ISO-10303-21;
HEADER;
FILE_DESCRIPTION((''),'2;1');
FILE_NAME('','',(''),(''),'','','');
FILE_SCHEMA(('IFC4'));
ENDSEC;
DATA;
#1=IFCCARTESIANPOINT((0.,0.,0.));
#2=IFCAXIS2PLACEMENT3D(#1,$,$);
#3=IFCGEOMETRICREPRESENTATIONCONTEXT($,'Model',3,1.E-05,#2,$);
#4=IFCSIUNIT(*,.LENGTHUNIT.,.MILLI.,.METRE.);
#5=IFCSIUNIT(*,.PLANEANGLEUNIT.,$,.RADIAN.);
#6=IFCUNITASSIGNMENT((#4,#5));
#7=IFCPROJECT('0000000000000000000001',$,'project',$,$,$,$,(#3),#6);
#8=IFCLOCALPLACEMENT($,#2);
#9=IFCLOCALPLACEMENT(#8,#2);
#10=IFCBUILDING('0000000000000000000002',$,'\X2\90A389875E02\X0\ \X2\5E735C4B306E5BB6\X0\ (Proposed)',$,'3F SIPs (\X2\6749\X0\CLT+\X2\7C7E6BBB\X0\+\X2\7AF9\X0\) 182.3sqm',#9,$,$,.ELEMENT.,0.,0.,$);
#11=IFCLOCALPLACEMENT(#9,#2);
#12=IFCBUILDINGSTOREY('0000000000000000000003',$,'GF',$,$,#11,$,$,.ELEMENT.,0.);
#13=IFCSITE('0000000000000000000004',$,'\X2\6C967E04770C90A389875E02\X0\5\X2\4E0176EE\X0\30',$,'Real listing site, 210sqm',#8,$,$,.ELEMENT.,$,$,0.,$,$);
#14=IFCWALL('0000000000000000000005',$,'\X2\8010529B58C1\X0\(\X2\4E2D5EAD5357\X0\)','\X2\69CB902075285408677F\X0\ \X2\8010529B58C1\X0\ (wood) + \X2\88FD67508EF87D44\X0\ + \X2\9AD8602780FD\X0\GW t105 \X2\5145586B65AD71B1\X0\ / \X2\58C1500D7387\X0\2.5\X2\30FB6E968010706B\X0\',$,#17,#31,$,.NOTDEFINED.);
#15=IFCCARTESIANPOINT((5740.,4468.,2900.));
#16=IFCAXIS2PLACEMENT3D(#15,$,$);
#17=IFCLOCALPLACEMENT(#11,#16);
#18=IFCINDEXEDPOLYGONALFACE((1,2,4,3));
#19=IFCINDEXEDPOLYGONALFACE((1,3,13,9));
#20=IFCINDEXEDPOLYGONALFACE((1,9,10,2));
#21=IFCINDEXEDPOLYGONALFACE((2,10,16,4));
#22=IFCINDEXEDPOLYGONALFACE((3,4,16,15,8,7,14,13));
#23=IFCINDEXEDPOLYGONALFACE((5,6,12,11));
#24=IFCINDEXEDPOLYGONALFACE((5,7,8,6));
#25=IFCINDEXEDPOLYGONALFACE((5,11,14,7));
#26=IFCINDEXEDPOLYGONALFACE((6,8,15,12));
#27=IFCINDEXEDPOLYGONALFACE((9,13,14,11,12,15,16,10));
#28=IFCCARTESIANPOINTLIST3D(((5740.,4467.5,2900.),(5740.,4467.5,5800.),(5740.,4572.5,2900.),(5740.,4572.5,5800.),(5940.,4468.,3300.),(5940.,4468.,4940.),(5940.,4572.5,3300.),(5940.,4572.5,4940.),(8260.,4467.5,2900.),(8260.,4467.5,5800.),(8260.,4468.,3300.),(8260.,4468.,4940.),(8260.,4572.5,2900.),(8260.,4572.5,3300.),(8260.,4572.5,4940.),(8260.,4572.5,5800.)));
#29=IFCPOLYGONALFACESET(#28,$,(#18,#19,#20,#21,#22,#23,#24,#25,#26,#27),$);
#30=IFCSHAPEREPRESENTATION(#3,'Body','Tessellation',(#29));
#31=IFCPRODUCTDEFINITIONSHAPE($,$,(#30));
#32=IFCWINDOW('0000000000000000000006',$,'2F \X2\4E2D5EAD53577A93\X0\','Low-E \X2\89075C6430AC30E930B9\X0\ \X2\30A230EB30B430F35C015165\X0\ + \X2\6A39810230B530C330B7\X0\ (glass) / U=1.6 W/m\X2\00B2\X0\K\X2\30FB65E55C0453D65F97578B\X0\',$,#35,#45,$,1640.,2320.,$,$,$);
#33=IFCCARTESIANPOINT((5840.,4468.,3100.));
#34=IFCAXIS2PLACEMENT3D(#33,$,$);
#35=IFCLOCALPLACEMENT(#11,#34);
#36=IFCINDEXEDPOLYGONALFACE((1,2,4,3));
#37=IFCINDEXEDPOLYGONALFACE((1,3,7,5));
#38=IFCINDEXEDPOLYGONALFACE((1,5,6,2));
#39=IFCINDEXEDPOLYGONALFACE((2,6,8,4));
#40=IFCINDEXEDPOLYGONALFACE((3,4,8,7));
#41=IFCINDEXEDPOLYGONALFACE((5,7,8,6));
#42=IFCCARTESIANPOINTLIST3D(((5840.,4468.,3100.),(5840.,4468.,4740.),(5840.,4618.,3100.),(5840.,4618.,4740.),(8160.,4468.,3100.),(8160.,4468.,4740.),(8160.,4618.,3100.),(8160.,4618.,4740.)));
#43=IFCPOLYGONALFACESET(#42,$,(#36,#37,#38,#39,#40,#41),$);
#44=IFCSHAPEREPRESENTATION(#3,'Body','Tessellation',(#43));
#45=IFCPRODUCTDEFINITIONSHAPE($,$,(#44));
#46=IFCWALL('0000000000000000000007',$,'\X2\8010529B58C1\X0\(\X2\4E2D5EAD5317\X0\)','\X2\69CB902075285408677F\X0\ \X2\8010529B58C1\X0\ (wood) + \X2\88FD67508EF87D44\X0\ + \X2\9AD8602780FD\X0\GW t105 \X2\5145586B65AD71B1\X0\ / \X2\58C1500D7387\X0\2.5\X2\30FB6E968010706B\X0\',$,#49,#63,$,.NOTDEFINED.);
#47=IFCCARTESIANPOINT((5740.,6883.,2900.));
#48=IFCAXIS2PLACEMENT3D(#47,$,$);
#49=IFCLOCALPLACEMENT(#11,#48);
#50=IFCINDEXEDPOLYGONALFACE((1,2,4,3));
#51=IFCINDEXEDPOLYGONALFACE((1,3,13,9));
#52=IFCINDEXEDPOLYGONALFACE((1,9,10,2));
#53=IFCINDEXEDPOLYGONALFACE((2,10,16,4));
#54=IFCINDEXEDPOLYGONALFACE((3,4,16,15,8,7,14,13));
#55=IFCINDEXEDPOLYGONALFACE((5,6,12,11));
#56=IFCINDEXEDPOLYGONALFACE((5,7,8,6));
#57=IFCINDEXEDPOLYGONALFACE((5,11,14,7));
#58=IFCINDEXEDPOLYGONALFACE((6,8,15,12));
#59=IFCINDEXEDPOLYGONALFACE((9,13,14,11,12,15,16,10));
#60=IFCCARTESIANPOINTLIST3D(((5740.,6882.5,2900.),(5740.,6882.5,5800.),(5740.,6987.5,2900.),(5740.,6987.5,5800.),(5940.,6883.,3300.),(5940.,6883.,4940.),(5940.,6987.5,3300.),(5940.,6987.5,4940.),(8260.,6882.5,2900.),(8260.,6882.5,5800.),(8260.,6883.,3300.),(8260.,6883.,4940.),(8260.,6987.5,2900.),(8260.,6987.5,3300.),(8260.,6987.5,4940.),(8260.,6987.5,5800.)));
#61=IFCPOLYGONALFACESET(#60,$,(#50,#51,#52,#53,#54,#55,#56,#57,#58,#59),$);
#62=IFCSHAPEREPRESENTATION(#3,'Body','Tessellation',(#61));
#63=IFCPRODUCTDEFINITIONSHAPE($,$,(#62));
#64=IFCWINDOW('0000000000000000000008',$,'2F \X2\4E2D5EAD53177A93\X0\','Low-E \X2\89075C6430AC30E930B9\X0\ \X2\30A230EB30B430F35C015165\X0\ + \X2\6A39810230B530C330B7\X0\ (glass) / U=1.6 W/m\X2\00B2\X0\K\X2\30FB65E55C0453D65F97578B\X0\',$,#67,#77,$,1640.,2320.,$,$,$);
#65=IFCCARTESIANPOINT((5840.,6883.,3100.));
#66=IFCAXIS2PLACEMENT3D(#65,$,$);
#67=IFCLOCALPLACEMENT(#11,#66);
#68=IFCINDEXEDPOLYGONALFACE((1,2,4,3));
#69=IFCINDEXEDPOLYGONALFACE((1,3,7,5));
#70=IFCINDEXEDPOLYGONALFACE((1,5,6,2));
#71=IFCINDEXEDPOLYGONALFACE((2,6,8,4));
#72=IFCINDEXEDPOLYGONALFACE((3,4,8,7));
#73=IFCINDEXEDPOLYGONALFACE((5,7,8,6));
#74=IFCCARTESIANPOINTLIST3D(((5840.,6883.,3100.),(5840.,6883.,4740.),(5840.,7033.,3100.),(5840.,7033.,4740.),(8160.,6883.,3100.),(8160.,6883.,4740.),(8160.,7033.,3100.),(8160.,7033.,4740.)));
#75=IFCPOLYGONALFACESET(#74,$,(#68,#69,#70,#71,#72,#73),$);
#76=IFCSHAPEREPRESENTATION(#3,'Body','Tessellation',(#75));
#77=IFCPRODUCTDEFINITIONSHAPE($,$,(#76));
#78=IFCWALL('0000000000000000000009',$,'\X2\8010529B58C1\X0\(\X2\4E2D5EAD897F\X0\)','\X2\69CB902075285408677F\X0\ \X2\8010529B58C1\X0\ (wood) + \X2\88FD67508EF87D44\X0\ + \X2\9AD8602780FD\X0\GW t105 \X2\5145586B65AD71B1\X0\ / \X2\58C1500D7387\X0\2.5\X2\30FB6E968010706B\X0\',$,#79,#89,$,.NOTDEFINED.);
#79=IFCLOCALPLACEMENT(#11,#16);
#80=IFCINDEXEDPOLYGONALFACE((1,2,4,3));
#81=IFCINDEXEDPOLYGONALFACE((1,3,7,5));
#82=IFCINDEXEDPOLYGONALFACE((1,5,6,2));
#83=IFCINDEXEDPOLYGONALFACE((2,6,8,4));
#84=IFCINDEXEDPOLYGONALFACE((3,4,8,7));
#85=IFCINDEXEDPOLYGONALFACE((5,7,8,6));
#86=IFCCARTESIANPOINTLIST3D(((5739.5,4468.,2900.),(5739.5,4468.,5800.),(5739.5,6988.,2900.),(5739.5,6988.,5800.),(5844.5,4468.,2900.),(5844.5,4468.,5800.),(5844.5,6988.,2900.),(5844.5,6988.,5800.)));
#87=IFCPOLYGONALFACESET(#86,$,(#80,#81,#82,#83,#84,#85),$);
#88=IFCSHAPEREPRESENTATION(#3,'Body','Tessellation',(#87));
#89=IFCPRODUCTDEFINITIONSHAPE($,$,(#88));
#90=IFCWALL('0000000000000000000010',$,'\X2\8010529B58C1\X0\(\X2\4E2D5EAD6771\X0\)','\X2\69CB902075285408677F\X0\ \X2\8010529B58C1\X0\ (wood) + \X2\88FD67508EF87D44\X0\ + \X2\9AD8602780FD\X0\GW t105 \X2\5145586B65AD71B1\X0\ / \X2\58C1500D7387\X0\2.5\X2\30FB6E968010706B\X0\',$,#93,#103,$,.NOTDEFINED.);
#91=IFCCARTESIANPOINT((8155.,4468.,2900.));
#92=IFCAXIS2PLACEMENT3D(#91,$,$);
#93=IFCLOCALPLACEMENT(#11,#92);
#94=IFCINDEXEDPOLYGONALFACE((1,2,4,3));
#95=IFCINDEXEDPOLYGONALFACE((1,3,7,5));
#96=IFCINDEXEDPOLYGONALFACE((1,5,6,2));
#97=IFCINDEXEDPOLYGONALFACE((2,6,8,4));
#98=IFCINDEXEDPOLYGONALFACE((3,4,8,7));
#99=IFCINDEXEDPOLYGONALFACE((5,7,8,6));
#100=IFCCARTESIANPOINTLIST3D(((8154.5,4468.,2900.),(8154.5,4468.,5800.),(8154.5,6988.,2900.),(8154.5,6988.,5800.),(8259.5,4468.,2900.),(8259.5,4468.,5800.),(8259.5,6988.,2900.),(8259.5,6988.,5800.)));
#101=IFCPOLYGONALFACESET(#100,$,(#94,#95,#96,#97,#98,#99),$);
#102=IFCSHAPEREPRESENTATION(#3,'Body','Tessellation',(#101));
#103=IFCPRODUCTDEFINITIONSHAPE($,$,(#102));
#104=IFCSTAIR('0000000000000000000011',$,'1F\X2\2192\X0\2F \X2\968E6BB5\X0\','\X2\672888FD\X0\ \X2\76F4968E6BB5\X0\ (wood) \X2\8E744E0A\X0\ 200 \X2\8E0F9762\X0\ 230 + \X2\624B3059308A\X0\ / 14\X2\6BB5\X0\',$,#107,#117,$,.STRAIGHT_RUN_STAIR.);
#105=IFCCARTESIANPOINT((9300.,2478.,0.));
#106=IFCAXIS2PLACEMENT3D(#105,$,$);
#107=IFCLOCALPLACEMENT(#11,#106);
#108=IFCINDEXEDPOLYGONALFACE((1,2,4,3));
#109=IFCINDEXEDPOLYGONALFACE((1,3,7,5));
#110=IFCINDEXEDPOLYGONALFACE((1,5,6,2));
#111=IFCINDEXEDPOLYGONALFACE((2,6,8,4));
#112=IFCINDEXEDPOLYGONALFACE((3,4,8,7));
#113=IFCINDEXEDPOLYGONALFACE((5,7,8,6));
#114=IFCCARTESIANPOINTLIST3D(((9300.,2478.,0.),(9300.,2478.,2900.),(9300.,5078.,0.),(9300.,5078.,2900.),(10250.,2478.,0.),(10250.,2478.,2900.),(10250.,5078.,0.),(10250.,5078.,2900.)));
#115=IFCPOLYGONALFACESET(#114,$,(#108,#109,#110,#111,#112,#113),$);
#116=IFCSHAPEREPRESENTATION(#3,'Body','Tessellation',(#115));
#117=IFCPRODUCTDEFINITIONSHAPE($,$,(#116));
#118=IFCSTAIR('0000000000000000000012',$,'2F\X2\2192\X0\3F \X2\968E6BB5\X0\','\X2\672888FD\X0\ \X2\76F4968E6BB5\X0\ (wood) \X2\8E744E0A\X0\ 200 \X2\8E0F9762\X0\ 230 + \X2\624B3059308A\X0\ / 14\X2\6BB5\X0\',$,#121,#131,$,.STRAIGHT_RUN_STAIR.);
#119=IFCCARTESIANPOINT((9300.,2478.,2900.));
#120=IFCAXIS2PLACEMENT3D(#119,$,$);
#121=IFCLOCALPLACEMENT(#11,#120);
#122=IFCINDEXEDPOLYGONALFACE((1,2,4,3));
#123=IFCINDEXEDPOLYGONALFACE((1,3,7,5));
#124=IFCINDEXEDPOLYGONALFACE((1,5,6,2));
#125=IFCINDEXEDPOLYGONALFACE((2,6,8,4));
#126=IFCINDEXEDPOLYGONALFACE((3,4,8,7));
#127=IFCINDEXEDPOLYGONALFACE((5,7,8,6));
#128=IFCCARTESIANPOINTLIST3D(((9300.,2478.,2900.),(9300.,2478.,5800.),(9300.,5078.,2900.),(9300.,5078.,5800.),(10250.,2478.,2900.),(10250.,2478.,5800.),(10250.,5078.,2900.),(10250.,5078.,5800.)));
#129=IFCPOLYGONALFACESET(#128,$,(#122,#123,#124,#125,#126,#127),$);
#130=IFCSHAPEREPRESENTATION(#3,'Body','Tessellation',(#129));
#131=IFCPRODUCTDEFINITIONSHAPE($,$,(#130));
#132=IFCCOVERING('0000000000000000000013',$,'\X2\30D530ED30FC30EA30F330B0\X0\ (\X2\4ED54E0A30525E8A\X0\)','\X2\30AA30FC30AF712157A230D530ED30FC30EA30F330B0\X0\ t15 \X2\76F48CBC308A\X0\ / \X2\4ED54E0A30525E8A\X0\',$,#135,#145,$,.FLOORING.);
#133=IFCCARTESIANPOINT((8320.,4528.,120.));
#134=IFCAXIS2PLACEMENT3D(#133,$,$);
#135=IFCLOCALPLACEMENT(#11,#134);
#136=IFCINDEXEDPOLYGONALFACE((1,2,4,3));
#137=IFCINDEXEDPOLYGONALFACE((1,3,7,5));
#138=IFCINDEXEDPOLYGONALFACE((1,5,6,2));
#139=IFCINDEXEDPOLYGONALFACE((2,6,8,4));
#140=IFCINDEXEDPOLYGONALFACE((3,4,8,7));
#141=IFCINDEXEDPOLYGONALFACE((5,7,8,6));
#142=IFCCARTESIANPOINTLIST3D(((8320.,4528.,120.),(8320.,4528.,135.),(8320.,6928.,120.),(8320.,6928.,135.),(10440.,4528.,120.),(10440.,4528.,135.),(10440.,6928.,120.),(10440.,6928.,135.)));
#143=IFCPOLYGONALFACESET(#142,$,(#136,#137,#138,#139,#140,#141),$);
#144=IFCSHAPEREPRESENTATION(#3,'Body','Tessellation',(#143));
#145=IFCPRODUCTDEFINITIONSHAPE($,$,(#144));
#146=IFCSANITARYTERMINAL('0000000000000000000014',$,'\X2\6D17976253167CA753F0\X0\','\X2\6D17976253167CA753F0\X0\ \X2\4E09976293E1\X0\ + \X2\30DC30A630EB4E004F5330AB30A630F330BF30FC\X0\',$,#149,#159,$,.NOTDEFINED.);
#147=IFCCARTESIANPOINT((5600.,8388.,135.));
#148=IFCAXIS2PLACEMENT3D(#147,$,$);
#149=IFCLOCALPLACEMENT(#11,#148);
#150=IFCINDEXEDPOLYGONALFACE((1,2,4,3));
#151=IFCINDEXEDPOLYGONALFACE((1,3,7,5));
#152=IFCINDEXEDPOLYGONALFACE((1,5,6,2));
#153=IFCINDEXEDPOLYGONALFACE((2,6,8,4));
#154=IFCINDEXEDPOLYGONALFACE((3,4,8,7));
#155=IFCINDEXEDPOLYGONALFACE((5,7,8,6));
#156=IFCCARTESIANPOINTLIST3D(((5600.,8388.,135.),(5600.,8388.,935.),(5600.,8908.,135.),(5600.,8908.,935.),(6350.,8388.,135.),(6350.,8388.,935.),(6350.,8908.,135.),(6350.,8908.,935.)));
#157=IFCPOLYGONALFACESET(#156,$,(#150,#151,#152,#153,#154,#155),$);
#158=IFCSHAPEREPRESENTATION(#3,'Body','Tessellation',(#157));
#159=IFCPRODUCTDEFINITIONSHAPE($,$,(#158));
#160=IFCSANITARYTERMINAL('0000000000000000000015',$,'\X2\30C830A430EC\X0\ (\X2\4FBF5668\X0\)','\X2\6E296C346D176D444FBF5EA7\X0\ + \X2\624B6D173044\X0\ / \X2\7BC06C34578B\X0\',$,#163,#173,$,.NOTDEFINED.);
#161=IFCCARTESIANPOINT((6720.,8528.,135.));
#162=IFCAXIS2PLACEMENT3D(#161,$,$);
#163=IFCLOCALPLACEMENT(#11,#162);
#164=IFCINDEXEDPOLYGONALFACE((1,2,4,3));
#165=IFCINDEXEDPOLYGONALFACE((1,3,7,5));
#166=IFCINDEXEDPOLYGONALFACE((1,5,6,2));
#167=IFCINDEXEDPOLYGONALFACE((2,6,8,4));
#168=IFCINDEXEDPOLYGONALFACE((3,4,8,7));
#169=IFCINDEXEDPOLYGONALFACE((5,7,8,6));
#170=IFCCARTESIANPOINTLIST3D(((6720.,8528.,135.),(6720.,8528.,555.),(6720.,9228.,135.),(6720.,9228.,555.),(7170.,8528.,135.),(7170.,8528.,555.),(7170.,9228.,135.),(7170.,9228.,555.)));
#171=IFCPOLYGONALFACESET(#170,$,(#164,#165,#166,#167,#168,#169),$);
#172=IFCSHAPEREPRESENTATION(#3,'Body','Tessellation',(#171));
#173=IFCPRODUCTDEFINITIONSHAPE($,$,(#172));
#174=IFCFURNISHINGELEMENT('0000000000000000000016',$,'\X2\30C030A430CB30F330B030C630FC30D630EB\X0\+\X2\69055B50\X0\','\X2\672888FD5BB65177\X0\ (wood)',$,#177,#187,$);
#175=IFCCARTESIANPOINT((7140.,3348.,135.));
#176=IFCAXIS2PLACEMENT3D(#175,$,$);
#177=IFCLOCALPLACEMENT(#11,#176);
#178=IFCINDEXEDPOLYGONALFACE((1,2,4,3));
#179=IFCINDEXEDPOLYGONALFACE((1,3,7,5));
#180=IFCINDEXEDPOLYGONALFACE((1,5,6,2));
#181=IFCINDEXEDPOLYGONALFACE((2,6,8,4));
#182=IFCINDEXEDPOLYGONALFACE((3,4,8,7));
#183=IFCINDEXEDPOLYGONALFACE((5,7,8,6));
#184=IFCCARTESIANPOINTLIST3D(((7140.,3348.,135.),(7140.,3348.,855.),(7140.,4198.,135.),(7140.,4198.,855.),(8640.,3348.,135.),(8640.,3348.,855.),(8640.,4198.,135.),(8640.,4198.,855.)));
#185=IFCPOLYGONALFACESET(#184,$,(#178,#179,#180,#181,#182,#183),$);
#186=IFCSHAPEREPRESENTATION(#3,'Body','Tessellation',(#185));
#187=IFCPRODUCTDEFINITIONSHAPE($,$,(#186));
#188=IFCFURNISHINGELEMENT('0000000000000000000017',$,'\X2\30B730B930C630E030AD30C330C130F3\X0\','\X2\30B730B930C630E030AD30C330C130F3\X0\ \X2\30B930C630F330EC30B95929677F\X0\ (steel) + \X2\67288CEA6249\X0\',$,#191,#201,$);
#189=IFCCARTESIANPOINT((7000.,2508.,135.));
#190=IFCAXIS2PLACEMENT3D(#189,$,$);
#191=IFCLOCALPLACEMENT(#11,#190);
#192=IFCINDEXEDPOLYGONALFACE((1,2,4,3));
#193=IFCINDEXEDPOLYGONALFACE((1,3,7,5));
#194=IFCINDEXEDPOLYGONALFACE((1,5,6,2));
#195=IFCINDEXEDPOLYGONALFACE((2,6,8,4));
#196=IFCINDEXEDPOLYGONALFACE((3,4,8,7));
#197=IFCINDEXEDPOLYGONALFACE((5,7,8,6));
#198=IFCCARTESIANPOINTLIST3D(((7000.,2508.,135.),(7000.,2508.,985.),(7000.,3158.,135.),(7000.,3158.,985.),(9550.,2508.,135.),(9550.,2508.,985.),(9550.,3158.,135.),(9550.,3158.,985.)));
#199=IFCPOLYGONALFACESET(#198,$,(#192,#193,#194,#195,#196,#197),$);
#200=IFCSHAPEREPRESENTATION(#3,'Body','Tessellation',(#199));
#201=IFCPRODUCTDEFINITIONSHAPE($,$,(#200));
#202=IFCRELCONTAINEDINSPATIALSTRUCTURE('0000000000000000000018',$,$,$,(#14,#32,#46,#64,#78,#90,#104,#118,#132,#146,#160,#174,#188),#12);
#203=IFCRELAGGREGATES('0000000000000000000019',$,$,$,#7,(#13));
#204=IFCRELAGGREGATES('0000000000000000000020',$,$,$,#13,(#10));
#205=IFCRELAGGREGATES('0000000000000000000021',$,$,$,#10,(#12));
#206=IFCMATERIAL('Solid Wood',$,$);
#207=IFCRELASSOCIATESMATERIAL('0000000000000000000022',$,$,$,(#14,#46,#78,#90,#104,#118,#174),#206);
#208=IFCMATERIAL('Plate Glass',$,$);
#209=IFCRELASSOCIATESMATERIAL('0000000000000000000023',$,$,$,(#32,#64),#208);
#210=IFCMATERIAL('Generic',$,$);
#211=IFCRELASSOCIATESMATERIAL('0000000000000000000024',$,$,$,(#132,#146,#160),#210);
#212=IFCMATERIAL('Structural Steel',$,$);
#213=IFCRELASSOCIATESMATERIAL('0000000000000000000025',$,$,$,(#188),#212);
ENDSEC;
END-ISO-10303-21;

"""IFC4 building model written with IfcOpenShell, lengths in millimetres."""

from ifc_helpers import new_model, si_unit, frame, frame_2d, origin, place, context, project, spatial, rectangle, extrude, material, element, fill, save


model = new_model("IFC4")

# Units and contexts
model_context = context("Model", 3, precision=1e-05, world=origin())
ifc_project = project(units=[si_unit("LENGTHUNIT", "METRE", prefix="MILLI"), si_unit("PLANEANGLEUNIT", "RADIAN")], contexts=[model_context])

# Site, building, storey
site_placement = place(None, origin())
site = spatial("IfcSite", under=ifc_project, at=site_placement, Name="沖縄県那覇市5丁目30", ObjectType="Real listing site, 210sqm", CompositionType="ELEMENT", RefElevation=0.0)
building_placement = place(site_placement, origin())
building = spatial("IfcBuilding", under=site, at=building_placement, Name="那覇市 平屋の家 (Proposed)", ObjectType="3F SIPs (杉CLT+籾殻+竹) 182.3sqm", CompositionType="ELEMENT", ElevationOfRefHeight=0.0, ElevationOfTerrain=0.0)
storey_placement = place(building_placement, origin())
storey = spatial("IfcBuildingStorey", under=building, at=storey_placement, Name="GF", CompositionType="ELEMENT", Elevation=0.0)

# Shared definitions
ifc_material_1 = material(Name="Solid Wood")

# Shared definitions
ifc_material_2 = material(Name="Plate Glass")

# Walls, openings, windows
wall_1_placement = place(storey_placement, frame((5740.0, 4468.0, 2900.0)))
wall_1 = element("IfcWall", 1, at=wall_1_placement, inside=storey, material=ifc_material_1, Name="耐力壁(中庭南)", Description="構造用合板 耐力壁 (wood) + 製材軸組 + 高性能GW t105 充填断熱 / 壁倍率2.5・準耐火", PredefinedType="NOTDEFINED", context=model_context, shape_type="SweptSolid", body=[
    extrude(rectangle(XDim=2520.0, YDim=105.0, at=frame_2d((1260.0, 52.0))), frame((5740.0, 4468.0, 2900.0)), (0.0, 0.0, 1.0), 2900.0),
])
opening_1_placement = place(storey_placement, frame((5840.0, 4468.0, 3100.0)))
opening_1 = element("IfcOpeningElement", 2, at=opening_1_placement, cuts=wall_1, PredefinedType="NOTDEFINED", context=model_context, shape_type="SweptSolid", body=[
    extrude(rectangle(XDim=2320.0, YDim=150.0, at=frame_2d((1160.0, 75.0))), frame((5840.0, 4468.0, 3100.0)), (0.0, 0.0, 1.0), 1640.0),
])
window_1_placement = place(storey_placement, frame((5840.0, 4468.0, 3100.0)))
window_1 = element("IfcWindow", 3, at=window_1_placement, inside=storey, material=ifc_material_2, Name="2F 中庭南窓", Description="Low-E 複層ガラス アルゴン封入 + 樹脂サッシ (glass) / U=1.6 W/m²K・日射取得型", OverallHeight=1640.0, OverallWidth=2320.0, context=model_context, shape_type="SweptSolid", body=[
    extrude(rectangle(XDim=2320.0, YDim=150.0, at=frame_2d((1160.0, 75.0))), frame((5840.0, 4468.0, 3100.0)), (0.0, 0.0, 1.0), 1640.0),
])
fill(opening_1, window_1)
wall_2_placement = place(storey_placement, frame((5740.0, 6883.0, 2900.0)))
wall_2 = element("IfcWall", 4, at=wall_2_placement, inside=storey, material=ifc_material_1, Name="耐力壁(中庭北)", Description="構造用合板 耐力壁 (wood) + 製材軸組 + 高性能GW t105 充填断熱 / 壁倍率2.5・準耐火", PredefinedType="NOTDEFINED", context=model_context, shape_type="SweptSolid", body=[
    extrude(rectangle(XDim=2520.0, YDim=105.0, at=frame_2d((1260.0, 52.0))), frame((5740.0, 6883.0, 2900.0)), (0.0, 0.0, 1.0), 2900.0),
])
opening_2_placement = place(storey_placement, frame((5840.0, 6883.0, 3100.0)))
opening_2 = element("IfcOpeningElement", 5, at=opening_2_placement, cuts=wall_2, PredefinedType="NOTDEFINED", context=model_context, shape_type="SweptSolid", body=[
    extrude(rectangle(XDim=2320.0, YDim=150.0, at=frame_2d((1160.0, 75.0))), frame((5840.0, 6883.0, 3100.0)), (0.0, 0.0, 1.0), 1640.0),
])
window_2_placement = place(storey_placement, frame((5840.0, 6883.0, 3100.0)))
window_2 = element("IfcWindow", 6, at=window_2_placement, inside=storey, material=ifc_material_2, Name="2F 中庭北窓", Description="Low-E 複層ガラス アルゴン封入 + 樹脂サッシ (glass) / U=1.6 W/m²K・日射取得型", OverallHeight=1640.0, OverallWidth=2320.0, context=model_context, shape_type="SweptSolid", body=[
    extrude(rectangle(XDim=2320.0, YDim=150.0, at=frame_2d((1160.0, 75.0))), frame((5840.0, 6883.0, 3100.0)), (0.0, 0.0, 1.0), 1640.0),
])
fill(opening_2, window_2)

# Walls
wall_3_placement = place(storey_placement, frame((5740.0, 4468.0, 2900.0)))
element("IfcWall", 7, at=wall_3_placement, inside=storey, material=ifc_material_1, Name="耐力壁(中庭西)", Description="構造用合板 耐力壁 (wood) + 製材軸組 + 高性能GW t105 充填断熱 / 壁倍率2.5・準耐火", PredefinedType="NOTDEFINED", context=model_context, shape_type="SweptSolid", body=[
    extrude(rectangle(XDim=105.0, YDim=2520.0, at=frame_2d((52.0, 1260.0))), frame((5740.0, 4468.0, 2900.0)), (0.0, 0.0, 1.0), 2900.0),
])
wall_4_placement = place(storey_placement, frame((8155.0, 4468.0, 2900.0)))
element("IfcWall", 8, at=wall_4_placement, inside=storey, material=ifc_material_1, Name="耐力壁(中庭東)", Description="構造用合板 耐力壁 (wood) + 製材軸組 + 高性能GW t105 充填断熱 / 壁倍率2.5・準耐火", PredefinedType="NOTDEFINED", context=model_context, shape_type="SweptSolid", body=[
    extrude(rectangle(XDim=105.0, YDim=2520.0, at=frame_2d((52.0, 1260.0))), frame((8155.0, 4468.0, 2900.0)), (0.0, 0.0, 1.0), 2900.0),
])

# Stairs
stair_1_placement = place(storey_placement, frame((9300.0, 2478.0, 0.0)))
element("IfcStair", 9, at=stair_1_placement, inside=storey, material=ifc_material_1, Name="1F→2F 階段", Description="木製 直階段 (wood) 蹴上 200 踏面 230 + 手すり / 14段", PredefinedType="STRAIGHT_RUN_STAIR", context=model_context, shape_type="SweptSolid", body=[
    extrude(rectangle(XDim=950.0, YDim=2600.0, at=frame_2d((475.0, 1300.0))), frame((9300.0, 2478.0, 0.0)), (0.0, 0.0, 1.0), 2900.0),
])
stair_2_placement = place(storey_placement, frame((9300.0, 2478.0, 2900.0)))
element("IfcStair", 10, at=stair_2_placement, inside=storey, material=ifc_material_1, Name="2F→3F 階段", Description="木製 直階段 (wood) 蹴上 200 踏面 230 + 手すり / 14段", PredefinedType="STRAIGHT_RUN_STAIR", context=model_context, shape_type="SweptSolid", body=[
    extrude(rectangle(XDim=950.0, YDim=2600.0, at=frame_2d((475.0, 1300.0))), frame((9300.0, 2478.0, 2900.0)), (0.0, 0.0, 1.0), 2900.0),
])

# Covering
ifc_material_3 = material(Name="Generic")
covering_placement = place(storey_placement, frame((8320.0, 4528.0, 120.0)))
element("IfcCovering", 11, at=covering_placement, inside=storey, material=ifc_material_3, Name="フローリング (仕上げ床)", Description="オーク無垢フローリング t15 直貼り / 仕上げ床", PredefinedType="FLOORING", context=model_context, shape_type="SweptSolid", body=[
    extrude(rectangle(XDim=2120.0, YDim=2400.0, at=frame_2d((1060.0, 1200.0))), frame((8320.0, 4528.0, 120.0)), (0.0, 0.0, 1.0), 15.0),
])

# Sanitary terminals
sanitary_terminal_1_placement = place(storey_placement, frame((5600.0, 8388.0, 135.0)))
element("IfcSanitaryTerminal", 12, at=sanitary_terminal_1_placement, inside=storey, material=ifc_material_3, Name="洗面化粧台", Description="洗面化粧台 三面鏡 + ボウル一体カウンター", PredefinedType="NOTDEFINED", context=model_context, shape_type="SweptSolid", body=[
    extrude(rectangle(XDim=750.0, YDim=520.0, at=frame_2d((375.0, 260.0))), frame((5600.0, 8388.0, 135.0)), (0.0, 0.0, 1.0), 800.0),
])
sanitary_terminal_2_placement = place(storey_placement, frame((6720.0, 8528.0, 135.0)))
element("IfcSanitaryTerminal", 13, at=sanitary_terminal_2_placement, inside=storey, material=ifc_material_3, Name="トイレ (便器)", Description="温水洗浄便座 + 手洗い / 節水型", PredefinedType="NOTDEFINED", context=model_context, shape_type="SweptSolid", body=[
    extrude(rectangle(XDim=450.0, YDim=700.0, at=frame_2d((225.0, 350.0))), frame((6720.0, 8528.0, 135.0)), (0.0, 0.0, 1.0), 420.0),
])

# Furnishing elements
furnishing_1_placement = place(storey_placement, frame((7140.0, 3348.0, 135.0)))
element("IfcFurnishingElement", 14, at=furnishing_1_placement, inside=storey, material=ifc_material_1, Name="ダイニングテーブル+椅子", Description="木製家具 (wood)", context=model_context, shape_type="SweptSolid", body=[
    extrude(rectangle(XDim=1500.0, YDim=850.0, at=frame_2d((750.0, 425.0))), frame((7140.0, 3348.0, 135.0)), (0.0, 0.0, 1.0), 720.0),
])
ifc_material_4 = material(Name="Structural Steel")
furnishing_2_placement = place(storey_placement, frame((7000.0, 2508.0, 135.0)))
element("IfcFurnishingElement", 15, at=furnishing_2_placement, inside=storey, material=ifc_material_4, Name="システムキッチン", Description="システムキッチン ステンレス天板 (steel) + 木質扉", context=model_context, shape_type="SweptSolid", body=[
    extrude(rectangle(XDim=2550.0, YDim=650.0, at=frame_2d((1275.0, 325.0))), frame((7000.0, 2508.0, 135.0)), (0.0, 0.0, 1.0), 850.0),
])

save(model, "model.ifc")
